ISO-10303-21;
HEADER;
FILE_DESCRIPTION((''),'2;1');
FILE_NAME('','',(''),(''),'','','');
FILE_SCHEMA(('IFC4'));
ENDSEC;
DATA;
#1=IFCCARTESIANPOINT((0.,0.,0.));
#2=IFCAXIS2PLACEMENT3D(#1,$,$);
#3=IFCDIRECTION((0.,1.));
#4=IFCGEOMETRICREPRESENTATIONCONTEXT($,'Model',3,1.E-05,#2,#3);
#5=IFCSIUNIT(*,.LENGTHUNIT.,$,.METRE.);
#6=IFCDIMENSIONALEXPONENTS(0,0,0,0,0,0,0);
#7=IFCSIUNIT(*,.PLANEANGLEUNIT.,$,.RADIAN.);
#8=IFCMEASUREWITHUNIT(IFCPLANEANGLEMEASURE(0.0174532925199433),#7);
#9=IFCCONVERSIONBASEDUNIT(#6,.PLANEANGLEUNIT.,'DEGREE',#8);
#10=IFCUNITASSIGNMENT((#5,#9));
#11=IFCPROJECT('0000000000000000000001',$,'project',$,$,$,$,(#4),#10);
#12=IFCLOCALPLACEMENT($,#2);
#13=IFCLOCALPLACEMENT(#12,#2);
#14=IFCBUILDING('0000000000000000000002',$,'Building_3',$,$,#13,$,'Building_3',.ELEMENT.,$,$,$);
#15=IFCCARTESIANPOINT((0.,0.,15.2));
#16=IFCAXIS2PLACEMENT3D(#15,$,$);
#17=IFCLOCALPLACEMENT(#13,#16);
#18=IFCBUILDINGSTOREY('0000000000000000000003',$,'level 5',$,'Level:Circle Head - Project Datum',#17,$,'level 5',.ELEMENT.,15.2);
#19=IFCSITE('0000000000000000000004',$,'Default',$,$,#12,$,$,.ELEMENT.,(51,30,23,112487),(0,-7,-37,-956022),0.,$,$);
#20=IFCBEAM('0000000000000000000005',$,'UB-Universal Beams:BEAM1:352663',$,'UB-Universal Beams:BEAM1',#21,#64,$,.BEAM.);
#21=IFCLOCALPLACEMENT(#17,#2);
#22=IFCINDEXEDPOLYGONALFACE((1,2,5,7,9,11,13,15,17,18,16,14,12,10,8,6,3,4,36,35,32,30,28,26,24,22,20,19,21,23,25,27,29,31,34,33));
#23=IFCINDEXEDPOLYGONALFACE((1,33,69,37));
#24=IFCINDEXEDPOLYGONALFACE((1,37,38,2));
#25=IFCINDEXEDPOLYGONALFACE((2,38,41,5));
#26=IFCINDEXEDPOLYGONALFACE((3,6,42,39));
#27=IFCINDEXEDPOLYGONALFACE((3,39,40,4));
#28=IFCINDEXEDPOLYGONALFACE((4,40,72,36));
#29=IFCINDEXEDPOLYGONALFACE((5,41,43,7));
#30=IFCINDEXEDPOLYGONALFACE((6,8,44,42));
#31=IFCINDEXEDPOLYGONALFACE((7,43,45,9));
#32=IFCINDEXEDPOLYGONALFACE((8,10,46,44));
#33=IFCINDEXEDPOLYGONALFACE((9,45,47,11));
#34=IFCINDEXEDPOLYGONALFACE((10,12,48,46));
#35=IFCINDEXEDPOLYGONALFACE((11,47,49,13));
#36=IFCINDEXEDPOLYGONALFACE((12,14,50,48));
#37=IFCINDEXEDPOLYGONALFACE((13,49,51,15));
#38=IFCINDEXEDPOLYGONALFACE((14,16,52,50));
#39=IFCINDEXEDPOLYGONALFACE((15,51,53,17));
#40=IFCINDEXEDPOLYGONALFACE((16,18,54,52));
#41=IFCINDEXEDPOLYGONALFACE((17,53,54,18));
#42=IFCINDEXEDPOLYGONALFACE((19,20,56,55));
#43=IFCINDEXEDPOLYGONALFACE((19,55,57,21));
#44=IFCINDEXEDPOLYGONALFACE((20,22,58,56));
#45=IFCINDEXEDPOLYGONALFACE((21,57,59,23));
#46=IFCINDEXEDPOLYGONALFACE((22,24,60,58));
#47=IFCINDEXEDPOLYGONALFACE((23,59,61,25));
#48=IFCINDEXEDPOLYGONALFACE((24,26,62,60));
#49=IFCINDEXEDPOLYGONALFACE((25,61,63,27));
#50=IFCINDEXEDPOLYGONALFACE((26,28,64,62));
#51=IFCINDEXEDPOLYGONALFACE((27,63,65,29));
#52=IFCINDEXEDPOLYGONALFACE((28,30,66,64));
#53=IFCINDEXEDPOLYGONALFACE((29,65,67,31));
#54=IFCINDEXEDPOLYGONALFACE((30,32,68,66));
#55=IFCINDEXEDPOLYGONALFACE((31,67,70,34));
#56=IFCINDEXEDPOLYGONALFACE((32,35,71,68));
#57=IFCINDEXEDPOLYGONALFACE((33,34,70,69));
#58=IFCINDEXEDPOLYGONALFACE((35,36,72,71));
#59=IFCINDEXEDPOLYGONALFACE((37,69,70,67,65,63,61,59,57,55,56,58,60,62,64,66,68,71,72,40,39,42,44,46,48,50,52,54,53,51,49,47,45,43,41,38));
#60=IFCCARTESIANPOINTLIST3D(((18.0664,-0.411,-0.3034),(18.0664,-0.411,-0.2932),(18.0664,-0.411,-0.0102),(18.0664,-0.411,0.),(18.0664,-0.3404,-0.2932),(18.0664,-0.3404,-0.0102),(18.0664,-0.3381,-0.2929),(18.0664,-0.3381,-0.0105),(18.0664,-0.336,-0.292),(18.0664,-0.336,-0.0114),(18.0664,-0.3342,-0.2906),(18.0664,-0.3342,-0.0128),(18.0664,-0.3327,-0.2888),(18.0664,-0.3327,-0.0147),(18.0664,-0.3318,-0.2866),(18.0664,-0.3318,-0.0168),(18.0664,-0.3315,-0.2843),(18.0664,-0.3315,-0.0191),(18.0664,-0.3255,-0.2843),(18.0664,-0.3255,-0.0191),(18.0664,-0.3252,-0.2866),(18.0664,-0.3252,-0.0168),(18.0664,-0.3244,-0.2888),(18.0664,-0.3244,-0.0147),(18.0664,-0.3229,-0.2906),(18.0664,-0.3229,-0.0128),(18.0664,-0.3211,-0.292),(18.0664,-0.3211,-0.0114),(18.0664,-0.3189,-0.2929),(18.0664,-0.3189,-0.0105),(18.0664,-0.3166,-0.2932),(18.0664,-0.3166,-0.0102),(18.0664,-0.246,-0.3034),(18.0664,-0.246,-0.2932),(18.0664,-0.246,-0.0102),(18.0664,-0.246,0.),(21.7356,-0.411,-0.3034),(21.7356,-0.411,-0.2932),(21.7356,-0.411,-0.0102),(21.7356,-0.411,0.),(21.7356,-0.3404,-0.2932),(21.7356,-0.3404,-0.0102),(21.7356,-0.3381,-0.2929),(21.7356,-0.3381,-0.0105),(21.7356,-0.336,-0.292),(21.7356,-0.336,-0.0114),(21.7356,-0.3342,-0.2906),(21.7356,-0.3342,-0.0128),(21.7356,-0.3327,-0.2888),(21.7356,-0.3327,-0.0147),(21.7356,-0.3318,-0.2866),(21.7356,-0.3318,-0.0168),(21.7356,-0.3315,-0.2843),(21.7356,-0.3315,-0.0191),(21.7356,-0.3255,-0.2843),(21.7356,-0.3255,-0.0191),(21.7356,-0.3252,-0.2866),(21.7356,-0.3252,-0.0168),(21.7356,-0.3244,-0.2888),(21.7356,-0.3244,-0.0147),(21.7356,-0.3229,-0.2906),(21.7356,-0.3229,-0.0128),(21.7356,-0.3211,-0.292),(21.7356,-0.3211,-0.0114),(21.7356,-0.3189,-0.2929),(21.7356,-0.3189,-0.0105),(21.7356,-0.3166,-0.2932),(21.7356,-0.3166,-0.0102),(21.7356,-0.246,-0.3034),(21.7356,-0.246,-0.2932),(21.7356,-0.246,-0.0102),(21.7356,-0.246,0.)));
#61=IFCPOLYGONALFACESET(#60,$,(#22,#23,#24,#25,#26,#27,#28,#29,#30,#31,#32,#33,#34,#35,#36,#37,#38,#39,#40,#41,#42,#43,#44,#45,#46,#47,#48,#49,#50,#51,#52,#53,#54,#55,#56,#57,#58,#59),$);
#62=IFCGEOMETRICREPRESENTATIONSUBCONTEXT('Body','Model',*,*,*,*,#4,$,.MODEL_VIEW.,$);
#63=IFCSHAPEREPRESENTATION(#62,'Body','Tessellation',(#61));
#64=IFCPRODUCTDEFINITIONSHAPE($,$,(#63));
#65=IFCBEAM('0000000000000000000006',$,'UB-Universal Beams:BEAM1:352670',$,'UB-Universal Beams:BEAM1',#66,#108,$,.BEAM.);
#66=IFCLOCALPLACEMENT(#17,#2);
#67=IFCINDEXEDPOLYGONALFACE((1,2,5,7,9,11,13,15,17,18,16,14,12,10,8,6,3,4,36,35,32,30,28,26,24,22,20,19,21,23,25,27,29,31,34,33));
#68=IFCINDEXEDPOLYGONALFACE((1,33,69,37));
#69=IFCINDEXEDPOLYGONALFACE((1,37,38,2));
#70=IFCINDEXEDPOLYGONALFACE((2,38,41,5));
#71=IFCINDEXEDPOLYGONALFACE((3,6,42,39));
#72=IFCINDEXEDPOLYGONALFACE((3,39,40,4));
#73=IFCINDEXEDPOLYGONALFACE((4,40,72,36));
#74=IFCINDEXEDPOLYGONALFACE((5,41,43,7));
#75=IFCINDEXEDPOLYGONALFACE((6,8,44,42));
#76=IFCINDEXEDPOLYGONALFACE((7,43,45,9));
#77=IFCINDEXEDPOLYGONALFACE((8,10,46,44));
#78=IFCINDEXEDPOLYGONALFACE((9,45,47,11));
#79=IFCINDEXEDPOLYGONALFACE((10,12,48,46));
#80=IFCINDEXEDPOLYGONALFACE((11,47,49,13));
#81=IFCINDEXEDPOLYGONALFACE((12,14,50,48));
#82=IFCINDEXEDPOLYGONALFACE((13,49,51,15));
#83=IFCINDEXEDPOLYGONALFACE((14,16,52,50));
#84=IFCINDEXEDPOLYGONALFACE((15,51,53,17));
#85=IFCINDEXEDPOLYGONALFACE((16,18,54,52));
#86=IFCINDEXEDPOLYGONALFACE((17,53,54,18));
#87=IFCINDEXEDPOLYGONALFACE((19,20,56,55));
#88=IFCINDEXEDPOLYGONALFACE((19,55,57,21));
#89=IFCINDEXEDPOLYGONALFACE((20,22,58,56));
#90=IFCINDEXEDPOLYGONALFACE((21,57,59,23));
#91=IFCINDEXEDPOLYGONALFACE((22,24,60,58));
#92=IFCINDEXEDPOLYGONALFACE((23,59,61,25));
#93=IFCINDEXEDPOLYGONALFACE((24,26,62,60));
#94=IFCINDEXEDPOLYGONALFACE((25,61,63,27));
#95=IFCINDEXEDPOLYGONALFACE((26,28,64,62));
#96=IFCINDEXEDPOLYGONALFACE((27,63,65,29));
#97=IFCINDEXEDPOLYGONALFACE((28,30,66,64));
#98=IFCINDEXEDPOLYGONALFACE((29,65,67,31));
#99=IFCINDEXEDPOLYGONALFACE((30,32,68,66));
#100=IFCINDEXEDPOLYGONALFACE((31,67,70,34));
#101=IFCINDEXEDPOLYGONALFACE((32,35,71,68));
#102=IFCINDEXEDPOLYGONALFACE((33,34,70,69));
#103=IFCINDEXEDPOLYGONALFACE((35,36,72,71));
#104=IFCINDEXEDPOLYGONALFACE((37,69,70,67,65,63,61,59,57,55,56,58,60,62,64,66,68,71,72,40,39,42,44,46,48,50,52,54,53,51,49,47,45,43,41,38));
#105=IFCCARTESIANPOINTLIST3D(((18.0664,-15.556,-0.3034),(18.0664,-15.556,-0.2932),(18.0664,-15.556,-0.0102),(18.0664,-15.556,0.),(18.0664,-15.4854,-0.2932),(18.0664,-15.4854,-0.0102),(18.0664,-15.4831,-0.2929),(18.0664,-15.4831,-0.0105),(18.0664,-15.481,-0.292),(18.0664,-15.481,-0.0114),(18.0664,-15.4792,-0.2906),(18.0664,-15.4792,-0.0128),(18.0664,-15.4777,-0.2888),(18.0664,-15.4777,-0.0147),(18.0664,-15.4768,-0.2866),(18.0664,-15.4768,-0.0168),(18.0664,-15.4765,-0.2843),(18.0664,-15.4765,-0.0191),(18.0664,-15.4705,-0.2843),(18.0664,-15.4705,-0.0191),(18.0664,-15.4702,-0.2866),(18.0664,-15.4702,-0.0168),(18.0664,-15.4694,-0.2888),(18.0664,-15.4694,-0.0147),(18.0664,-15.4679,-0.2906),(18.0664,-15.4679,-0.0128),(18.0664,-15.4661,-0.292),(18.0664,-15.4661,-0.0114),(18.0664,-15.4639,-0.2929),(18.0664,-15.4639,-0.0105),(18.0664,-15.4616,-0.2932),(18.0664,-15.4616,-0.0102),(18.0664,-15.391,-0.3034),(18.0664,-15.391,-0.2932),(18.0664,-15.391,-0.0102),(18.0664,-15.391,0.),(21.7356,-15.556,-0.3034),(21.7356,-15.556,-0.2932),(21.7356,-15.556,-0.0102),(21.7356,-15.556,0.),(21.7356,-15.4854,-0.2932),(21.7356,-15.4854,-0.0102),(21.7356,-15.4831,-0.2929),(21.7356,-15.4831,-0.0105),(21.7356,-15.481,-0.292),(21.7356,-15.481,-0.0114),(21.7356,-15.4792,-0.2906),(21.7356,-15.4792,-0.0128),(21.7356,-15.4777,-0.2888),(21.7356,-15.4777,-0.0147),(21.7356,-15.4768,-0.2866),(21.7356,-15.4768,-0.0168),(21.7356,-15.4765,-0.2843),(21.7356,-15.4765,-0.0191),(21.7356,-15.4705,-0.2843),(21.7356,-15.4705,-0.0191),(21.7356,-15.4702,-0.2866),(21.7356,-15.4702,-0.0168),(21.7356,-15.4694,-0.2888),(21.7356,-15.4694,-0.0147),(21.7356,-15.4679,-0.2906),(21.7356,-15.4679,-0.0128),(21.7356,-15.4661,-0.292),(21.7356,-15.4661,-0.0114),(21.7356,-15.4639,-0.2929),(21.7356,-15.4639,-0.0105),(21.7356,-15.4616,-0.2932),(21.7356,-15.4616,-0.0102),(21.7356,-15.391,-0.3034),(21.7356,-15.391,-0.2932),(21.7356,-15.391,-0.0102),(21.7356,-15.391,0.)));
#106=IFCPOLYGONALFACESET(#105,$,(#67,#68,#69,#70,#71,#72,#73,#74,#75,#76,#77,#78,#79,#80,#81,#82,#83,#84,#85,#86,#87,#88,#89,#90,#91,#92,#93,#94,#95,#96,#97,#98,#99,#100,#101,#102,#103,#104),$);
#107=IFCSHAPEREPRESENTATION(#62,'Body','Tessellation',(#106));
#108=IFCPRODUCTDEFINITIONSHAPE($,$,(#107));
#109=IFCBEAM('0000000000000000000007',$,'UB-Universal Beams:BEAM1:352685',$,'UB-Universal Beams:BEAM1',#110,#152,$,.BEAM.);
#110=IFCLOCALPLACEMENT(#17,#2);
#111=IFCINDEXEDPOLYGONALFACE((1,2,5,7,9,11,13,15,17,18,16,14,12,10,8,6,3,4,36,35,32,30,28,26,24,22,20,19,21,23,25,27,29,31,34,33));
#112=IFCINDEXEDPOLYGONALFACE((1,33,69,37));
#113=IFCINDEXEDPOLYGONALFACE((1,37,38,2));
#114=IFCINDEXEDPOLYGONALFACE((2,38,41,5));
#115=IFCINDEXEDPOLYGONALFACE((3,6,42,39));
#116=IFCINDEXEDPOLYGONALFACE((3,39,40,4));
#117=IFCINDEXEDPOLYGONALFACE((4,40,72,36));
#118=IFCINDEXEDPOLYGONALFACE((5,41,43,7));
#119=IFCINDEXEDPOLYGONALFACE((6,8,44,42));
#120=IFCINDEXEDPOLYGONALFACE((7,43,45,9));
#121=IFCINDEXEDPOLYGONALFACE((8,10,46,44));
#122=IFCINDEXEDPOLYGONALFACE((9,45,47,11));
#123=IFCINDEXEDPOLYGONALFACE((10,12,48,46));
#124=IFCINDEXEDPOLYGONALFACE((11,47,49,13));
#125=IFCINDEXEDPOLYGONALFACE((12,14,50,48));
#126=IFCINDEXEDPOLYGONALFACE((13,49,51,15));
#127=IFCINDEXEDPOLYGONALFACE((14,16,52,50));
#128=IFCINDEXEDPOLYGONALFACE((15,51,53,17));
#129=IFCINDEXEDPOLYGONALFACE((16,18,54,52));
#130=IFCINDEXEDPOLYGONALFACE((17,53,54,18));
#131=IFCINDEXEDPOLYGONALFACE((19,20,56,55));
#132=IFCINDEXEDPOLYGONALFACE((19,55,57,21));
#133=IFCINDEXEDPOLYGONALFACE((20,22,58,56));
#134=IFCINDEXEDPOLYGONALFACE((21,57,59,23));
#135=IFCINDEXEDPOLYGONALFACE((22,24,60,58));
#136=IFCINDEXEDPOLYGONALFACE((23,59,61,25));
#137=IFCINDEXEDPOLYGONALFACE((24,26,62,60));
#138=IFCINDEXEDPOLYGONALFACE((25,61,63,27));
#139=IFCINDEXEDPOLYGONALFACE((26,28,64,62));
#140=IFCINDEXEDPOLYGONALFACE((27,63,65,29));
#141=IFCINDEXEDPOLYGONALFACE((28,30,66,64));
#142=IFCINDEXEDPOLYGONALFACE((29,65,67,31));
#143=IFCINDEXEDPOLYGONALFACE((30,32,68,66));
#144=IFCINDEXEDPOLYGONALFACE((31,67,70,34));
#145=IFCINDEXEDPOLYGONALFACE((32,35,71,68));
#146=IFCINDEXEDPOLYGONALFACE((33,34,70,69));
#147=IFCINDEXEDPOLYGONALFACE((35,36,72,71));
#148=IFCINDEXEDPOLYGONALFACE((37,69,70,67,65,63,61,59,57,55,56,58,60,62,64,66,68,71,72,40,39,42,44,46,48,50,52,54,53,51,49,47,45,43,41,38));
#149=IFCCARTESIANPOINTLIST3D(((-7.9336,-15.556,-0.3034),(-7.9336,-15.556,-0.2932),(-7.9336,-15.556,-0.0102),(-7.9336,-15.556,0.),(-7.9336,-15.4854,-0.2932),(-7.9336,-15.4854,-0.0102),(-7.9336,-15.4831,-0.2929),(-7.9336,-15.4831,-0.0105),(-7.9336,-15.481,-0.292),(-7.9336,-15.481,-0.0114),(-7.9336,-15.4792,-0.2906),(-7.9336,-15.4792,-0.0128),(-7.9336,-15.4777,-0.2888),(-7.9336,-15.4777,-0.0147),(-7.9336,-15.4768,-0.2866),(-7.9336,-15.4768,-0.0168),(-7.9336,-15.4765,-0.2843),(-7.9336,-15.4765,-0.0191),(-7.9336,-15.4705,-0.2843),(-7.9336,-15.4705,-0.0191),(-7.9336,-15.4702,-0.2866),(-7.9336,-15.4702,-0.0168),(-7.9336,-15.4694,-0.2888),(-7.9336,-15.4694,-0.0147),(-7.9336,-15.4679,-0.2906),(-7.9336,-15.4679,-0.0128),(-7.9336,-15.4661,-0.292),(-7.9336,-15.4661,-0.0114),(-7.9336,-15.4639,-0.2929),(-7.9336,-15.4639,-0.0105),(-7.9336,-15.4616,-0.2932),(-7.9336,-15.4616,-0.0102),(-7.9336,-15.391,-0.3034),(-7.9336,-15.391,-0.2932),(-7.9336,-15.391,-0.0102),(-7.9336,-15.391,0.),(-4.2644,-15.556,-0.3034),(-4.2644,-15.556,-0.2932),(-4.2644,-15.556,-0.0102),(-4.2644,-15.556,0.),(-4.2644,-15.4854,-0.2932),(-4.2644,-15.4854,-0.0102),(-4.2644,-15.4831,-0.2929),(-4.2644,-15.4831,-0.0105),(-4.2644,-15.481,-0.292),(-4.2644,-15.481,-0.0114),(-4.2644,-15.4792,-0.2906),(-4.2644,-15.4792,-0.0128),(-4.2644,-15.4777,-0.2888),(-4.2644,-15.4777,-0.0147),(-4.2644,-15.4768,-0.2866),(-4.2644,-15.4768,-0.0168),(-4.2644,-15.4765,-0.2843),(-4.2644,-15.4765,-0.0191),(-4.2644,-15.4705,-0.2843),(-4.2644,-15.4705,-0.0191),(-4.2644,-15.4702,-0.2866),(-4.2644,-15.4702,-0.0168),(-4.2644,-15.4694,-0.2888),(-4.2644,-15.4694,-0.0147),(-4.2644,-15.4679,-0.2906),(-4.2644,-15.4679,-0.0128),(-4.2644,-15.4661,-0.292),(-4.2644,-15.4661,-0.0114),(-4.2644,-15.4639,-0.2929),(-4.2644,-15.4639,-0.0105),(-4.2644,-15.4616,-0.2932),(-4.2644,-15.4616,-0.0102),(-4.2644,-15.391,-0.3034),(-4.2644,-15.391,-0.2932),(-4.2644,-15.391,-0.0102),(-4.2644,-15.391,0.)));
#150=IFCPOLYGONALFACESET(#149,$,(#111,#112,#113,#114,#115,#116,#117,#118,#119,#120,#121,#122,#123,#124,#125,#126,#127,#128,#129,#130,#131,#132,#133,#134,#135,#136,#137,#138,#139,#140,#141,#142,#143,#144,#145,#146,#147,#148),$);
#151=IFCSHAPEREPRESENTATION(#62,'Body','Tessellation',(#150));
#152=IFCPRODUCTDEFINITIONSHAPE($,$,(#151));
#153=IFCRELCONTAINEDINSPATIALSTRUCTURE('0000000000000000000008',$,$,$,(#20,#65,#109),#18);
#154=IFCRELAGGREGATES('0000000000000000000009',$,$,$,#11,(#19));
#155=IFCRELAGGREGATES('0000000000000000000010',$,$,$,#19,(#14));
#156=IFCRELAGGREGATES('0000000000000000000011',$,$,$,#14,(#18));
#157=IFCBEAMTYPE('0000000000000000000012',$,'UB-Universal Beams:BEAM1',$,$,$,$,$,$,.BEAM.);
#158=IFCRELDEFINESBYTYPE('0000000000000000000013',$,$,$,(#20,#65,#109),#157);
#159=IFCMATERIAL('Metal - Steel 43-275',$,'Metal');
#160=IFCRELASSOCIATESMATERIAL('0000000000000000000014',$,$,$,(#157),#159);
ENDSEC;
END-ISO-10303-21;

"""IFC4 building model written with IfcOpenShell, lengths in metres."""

from ifc_helpers import new_model, entity, si_unit, converted_unit, direction, frame, frame_2d, origin, place, context, subcontext, project, spatial, polyline, circle_curve, parameter, trimmed, segment, composite_curve, outline, extrude, source, transform, mapped, material, material_profile, profile_set, type_object, type_shapes, element, save


model = new_model("IFC4")

# Units and contexts
model_context = context("Model", 3, precision=1e-05, world=origin(), true_north=direction((0.0, 1.0)))
body_context = subcontext(model_context, "Body", "Model", "MODEL_VIEW")
ifc_project = project(units=[si_unit("LENGTHUNIT", "METRE"), converted_unit("PLANEANGLEUNIT", "DEGREE", entity("IfcPlaneAngleMeasure", 0.0174532925199433), si_unit("PLANEANGLEUNIT", "RADIAN"), dimensions=[0, 0, 0, 0, 0, 0, 0])], contexts=[model_context])

# Site, building, storey
site_placement = place(None, origin())
site = spatial("IfcSite", under=ifc_project, at=site_placement, Name="Default", CompositionType="ELEMENT", RefLatitude=(51, 30, 23, 112487), RefLongitude=(0, -7, -37, -956022), RefElevation=0.0)
building_placement = place(site_placement, origin())
building = spatial("IfcBuilding", under=site, at=building_placement, Name="Building_3", LongName="Building_3", CompositionType="ELEMENT")
storey_placement = place(building_placement, frame((0.0, 0.0, 15.2)))
storey = spatial("IfcBuildingStorey", under=building, at=storey_placement, Name="level 5", ObjectType="Level:Circle Head - Project Datum", LongName="level 5", CompositionType="ELEMENT", Elevation=15.2)

# Beams
ifc_material_1 = material(Name="Metal - Steel 43-275", Category="Metal")
ifc_material_profile = material_profile(ifc_material_1, outline(composite_curve([segment(polyline([(-0.0825, -0.1415), (-0.0825, -0.1517)]), True, "CONTINUOUS"), segment(polyline([(-0.0825, -0.1517), (0.0825, -0.1517)]), True, "CONTINUOUS"), segment(polyline([(0.0825, -0.1517), (0.0825, -0.1415)]), True, "CONTINUOUS"), segment(polyline([(0.0825, -0.1415), (0.0119, -0.1415)]), True, "CONTINUOUS"), segment(trimmed(circle_curve(frame_2d((0.0119, -0.1326), x_axis=(1.0, 0.0)), 0.0089), [parameter(180.0)], [parameter(270.0)], True, "PARAMETER"), False, "CONTINUOUS"), segment(polyline([(0.003, -0.1326), (0.003, 0.1326)]), True, "CONTINUOUS"), segment(trimmed(circle_curve(frame_2d((0.0119, 0.1326), x_axis=(1.0, 0.0)), 0.0089), [parameter(90.0)], [parameter(180.0)], True, "PARAMETER"), False, "CONTINUOUS"), segment(polyline([(0.0119, 0.1415), (0.0825, 0.1415)]), True, "CONTINUOUS"), segment(polyline([(0.0825, 0.1415), (0.0825, 0.1517)]), True, "CONTINUOUS"), segment(polyline([(0.0825, 0.1517), (-0.0825, 0.1517)]), True, "CONTINUOUS"), segment(polyline([(-0.0825, 0.1517), (-0.0825, 0.1415)]), True, "CONTINUOUS"), segment(polyline([(-0.0825, 0.1415), (-0.0119, 0.1415)]), True, "CONTINUOUS"), segment(trimmed(circle_curve(frame_2d((-0.0119, 0.1326), x_axis=(1.0, 0.0)), 0.0089), [parameter(360.0)], [parameter(90.0)], True, "PARAMETER"), False, "CONTINUOUS"), segment(polyline([(-0.003, 0.1326), (-0.003, -0.1326)]), True, "CONTINUOUS"), segment(trimmed(circle_curve(frame_2d((-0.0119, -0.1326), x_axis=(1.0, 0.0)), 0.0089), [parameter(270.0)], [parameter(360.0)], True, "PARAMETER"), False, "CONTINUOUS"), segment(polyline([(-0.0119, -0.1415), (-0.0825, -0.1415)]), True, "CONTINUOUS")], self_intersect=False)), Name="BEAM1")
ifc_profile_set = profile_set([ifc_material_profile], Name="BEAM1")
beam_type_1 = type_object("IfcBeamType", Name="UB-Universal Beams:BEAM1", PredefinedType="BEAM", material=ifc_profile_set)
shared_shape_1 = source(origin(), body_context, "Body", "SweptSolid", [
    extrude(outline(composite_curve([segment(polyline([(-0.0825, -0.1415), (-0.0825, -0.1517)]), True, "CONTINUOUS"), segment(polyline([(-0.0825, -0.1517), (0.0825, -0.1517)]), True, "CONTINUOUS"), segment(polyline([(0.0825, -0.1517), (0.0825, -0.1415)]), True, "CONTINUOUS"), segment(polyline([(0.0825, -0.1415), (0.0119, -0.1415)]), True, "CONTINUOUS"), segment(trimmed(circle_curve(frame_2d((0.0119, -0.1326), x_axis=(0.0, -1.0)), 0.0089), [parameter(270.0)], [parameter(360.0)], True, "PARAMETER"), False, "CONTINUOUS"), segment(polyline([(0.003, -0.1326), (0.003, 0.1326)]), True, "CONTINUOUS"), segment(trimmed(circle_curve(frame_2d((0.0119, 0.1326), x_axis=(-1.0, 0.0)), 0.0089), [parameter(270.0)], [parameter(360.0)], True, "PARAMETER"), False, "CONTINUOUS"), segment(polyline([(0.0119, 0.1415), (0.0825, 0.1415)]), True, "CONTINUOUS"), segment(polyline([(0.0825, 0.1415), (0.0825, 0.1517)]), True, "CONTINUOUS"), segment(polyline([(0.0825, 0.1517), (-0.0825, 0.1517)]), True, "CONTINUOUS"), segment(polyline([(-0.0825, 0.1517), (-0.0825, 0.1415)]), True, "CONTINUOUS"), segment(polyline([(-0.0825, 0.1415), (-0.0119, 0.1415)]), True, "CONTINUOUS"), segment(trimmed(circle_curve(frame_2d((-0.0119, 0.1326), x_axis=(0.0, 1.0)), 0.0089), [parameter(270.0)], [parameter(360.0)], True, "PARAMETER"), False, "CONTINUOUS"), segment(polyline([(-0.003, 0.1326), (-0.003, -0.1326)]), True, "CONTINUOUS"), segment(trimmed(circle_curve(frame_2d((-0.0119, -0.1326), x_axis=(1.0, 0.0)), 0.0089), [parameter(270.0)], [parameter(0.0)], True, "PARAMETER"), False, "CONTINUOUS"), segment(polyline([(-0.0119, -0.1415), (-0.0825, -0.1415)]), True, "CONTINUOUS")], self_intersect=False)), frame((-1.8346, 0.0, 0.0), z_axis=(-1.0, 0.0, 0.0), x_axis=(0.0, -1.0, 0.0)), (0.0, 0.0, -1.0), 3.6692),
])
type_shapes(beam_type_1, [shared_shape_1])
for number, where, name in (
    (1, (19.901, -0.3285, -0.1517), "UB-Universal Beams:BEAM1:352663"),
    (2, (19.901, -15.4735, -0.1517), "UB-Universal Beams:BEAM1:352670"),
):
    element("IfcBeam", number, at=place(storey_placement, frame(where)), inside=storey, type_object=beam_type_1, Name=name, ObjectType="UB-Universal Beams:BEAM1", PredefinedType="BEAM", context=body_context, shape_type="MappedRepresentation", body=[
        mapped(shared_shape_1, transform((0.0, 0.0, 0.0), scale=1.0)),
    ])
beam_1_placement = place(storey_placement, frame((-6.099, -15.4735, -0.1517), z_axis=(0.0, 0.0, 1.0), x_axis=(-1.0, 0.0, 0.0)))
element("IfcBeam", 3, at=beam_1_placement, inside=storey, type_object=beam_type_1, Name="UB-Universal Beams:BEAM1:352685", ObjectType="UB-Universal Beams:BEAM1", PredefinedType="BEAM", context=body_context, shape_type="MappedRepresentation", body=[
    mapped(shared_shape_1, transform((0.0, 0.0, 0.0), scale=1.0)),
])

save(model, "model.ifc")
